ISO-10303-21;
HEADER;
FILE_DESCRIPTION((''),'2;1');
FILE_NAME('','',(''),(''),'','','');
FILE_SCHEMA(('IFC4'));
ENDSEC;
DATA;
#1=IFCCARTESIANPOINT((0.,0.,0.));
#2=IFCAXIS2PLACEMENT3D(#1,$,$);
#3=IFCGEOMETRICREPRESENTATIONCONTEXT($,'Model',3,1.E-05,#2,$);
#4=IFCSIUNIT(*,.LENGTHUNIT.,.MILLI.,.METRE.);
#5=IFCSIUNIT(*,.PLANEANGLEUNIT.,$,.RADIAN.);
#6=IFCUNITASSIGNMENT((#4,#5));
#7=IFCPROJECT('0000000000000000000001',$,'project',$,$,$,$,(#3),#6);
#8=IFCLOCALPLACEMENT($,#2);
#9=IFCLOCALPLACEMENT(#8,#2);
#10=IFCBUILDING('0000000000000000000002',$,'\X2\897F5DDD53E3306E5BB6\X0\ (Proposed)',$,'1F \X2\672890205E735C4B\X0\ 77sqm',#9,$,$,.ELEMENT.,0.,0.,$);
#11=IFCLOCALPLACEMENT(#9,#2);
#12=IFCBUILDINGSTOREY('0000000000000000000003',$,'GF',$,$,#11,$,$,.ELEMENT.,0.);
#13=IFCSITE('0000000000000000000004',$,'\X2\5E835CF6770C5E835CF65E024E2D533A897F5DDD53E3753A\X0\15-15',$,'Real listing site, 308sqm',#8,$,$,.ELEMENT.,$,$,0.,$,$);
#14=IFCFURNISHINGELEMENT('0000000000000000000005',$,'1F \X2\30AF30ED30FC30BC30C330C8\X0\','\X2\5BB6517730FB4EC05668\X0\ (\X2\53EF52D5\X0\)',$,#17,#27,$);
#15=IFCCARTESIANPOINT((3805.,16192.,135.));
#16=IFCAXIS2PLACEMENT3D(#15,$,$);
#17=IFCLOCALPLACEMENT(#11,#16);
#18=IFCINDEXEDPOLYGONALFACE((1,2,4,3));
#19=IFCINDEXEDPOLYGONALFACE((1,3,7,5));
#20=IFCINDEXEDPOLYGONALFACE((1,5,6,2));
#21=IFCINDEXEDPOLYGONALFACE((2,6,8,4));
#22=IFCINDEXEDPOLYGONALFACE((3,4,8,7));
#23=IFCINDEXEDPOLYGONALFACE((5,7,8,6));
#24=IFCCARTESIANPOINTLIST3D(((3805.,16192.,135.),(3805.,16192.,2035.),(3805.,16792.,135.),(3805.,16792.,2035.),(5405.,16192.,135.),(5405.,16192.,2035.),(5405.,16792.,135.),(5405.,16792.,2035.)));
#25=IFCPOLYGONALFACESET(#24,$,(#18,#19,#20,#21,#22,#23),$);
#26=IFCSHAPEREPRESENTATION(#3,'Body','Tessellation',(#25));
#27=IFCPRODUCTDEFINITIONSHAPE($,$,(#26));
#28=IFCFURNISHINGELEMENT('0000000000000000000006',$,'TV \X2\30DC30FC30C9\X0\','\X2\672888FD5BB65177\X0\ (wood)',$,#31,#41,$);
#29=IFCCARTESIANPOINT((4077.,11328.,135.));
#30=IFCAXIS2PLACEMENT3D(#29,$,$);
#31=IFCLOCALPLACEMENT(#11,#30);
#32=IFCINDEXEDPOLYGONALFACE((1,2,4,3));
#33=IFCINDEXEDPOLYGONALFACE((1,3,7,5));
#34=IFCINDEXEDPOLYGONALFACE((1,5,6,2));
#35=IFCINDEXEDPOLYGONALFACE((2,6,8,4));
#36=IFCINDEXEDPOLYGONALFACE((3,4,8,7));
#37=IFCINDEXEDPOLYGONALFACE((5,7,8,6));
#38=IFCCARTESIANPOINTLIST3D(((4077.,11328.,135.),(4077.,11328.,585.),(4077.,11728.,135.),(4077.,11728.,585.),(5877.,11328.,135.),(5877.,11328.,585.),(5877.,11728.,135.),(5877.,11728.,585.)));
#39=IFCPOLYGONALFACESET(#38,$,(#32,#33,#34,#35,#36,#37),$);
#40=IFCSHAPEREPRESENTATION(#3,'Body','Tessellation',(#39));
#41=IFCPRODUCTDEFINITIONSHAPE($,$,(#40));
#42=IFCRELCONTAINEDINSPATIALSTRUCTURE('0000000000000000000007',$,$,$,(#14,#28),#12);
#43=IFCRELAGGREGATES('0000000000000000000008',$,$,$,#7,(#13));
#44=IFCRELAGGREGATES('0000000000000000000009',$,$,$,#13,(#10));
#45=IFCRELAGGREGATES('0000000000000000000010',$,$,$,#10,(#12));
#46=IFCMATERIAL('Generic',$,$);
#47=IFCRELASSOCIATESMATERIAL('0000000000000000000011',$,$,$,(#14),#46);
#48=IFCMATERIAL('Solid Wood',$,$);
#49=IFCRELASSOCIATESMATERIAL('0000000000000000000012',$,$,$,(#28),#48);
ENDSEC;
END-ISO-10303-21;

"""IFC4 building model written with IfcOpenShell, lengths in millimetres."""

from ifc_helpers import new_model, si_unit, frame, frame_2d, origin, place, context, project, spatial, rectangle, extrude, material, element, save


model = new_model("IFC4")

# Units and contexts
model_context = context("Model", 3, precision=1e-05, world=origin())
ifc_project = project(units=[si_unit("LENGTHUNIT", "METRE", prefix="MILLI"), si_unit("PLANEANGLEUNIT", "RADIAN")], contexts=[model_context])

# Site, building, storey
site_placement = place(None, origin())
site = spatial("IfcSite", under=ifc_project, at=site_placement, Name="広島県広島市中区西川口町15-15", ObjectType="Real listing site, 308sqm", CompositionType="ELEMENT", RefElevation=0.0)
building_placement = place(site_placement, origin())
building = spatial("IfcBuilding", under=site, at=building_placement, Name="西川口の家 (Proposed)", ObjectType="1F 木造平屋 77sqm", CompositionType="ELEMENT", ElevationOfRefHeight=0.0, ElevationOfTerrain=0.0)
storey_placement = place(building_placement, origin())
storey = spatial("IfcBuildingStorey", under=building, at=storey_placement, Name="GF", CompositionType="ELEMENT", Elevation=0.0)

# Shared definitions
ifc_material_1 = material(Name="Solid Wood")

# Shared definitions
ifc_material_2 = material(Name="Generic")

# Furnishing elements
furnishing_1_placement = place(storey_placement, frame((3805.0, 16192.0, 135.0)))
element("IfcFurnishingElement", 1, at=furnishing_1_placement, inside=storey, material=ifc_material_2, Name="1F クローゼット", Description="家具・什器 (可動)", context=model_context, shape_type="SweptSolid", body=[
    extrude(rectangle(XDim=1600.0, YDim=600.0, at=frame_2d((800.0, 300.0))), frame((3805.0, 16192.0, 135.0)), (0.0, 0.0, 1.0), 1900.0),
])
furnishing_2_placement = place(storey_placement, frame((4077.0, 11328.0, 135.0)))
element("IfcFurnishingElement", 2, at=furnishing_2_placement, inside=storey, material=ifc_material_1, Name="TV ボード", Description="木製家具 (wood)", context=model_context, shape_type="SweptSolid", body=[
    extrude(rectangle(XDim=1800.0, YDim=400.0, at=frame_2d((900.0, 200.0))), frame((4077.0, 11328.0, 135.0)), (0.0, 0.0, 1.0), 450.0),
])

save(model, "model.ifc")
